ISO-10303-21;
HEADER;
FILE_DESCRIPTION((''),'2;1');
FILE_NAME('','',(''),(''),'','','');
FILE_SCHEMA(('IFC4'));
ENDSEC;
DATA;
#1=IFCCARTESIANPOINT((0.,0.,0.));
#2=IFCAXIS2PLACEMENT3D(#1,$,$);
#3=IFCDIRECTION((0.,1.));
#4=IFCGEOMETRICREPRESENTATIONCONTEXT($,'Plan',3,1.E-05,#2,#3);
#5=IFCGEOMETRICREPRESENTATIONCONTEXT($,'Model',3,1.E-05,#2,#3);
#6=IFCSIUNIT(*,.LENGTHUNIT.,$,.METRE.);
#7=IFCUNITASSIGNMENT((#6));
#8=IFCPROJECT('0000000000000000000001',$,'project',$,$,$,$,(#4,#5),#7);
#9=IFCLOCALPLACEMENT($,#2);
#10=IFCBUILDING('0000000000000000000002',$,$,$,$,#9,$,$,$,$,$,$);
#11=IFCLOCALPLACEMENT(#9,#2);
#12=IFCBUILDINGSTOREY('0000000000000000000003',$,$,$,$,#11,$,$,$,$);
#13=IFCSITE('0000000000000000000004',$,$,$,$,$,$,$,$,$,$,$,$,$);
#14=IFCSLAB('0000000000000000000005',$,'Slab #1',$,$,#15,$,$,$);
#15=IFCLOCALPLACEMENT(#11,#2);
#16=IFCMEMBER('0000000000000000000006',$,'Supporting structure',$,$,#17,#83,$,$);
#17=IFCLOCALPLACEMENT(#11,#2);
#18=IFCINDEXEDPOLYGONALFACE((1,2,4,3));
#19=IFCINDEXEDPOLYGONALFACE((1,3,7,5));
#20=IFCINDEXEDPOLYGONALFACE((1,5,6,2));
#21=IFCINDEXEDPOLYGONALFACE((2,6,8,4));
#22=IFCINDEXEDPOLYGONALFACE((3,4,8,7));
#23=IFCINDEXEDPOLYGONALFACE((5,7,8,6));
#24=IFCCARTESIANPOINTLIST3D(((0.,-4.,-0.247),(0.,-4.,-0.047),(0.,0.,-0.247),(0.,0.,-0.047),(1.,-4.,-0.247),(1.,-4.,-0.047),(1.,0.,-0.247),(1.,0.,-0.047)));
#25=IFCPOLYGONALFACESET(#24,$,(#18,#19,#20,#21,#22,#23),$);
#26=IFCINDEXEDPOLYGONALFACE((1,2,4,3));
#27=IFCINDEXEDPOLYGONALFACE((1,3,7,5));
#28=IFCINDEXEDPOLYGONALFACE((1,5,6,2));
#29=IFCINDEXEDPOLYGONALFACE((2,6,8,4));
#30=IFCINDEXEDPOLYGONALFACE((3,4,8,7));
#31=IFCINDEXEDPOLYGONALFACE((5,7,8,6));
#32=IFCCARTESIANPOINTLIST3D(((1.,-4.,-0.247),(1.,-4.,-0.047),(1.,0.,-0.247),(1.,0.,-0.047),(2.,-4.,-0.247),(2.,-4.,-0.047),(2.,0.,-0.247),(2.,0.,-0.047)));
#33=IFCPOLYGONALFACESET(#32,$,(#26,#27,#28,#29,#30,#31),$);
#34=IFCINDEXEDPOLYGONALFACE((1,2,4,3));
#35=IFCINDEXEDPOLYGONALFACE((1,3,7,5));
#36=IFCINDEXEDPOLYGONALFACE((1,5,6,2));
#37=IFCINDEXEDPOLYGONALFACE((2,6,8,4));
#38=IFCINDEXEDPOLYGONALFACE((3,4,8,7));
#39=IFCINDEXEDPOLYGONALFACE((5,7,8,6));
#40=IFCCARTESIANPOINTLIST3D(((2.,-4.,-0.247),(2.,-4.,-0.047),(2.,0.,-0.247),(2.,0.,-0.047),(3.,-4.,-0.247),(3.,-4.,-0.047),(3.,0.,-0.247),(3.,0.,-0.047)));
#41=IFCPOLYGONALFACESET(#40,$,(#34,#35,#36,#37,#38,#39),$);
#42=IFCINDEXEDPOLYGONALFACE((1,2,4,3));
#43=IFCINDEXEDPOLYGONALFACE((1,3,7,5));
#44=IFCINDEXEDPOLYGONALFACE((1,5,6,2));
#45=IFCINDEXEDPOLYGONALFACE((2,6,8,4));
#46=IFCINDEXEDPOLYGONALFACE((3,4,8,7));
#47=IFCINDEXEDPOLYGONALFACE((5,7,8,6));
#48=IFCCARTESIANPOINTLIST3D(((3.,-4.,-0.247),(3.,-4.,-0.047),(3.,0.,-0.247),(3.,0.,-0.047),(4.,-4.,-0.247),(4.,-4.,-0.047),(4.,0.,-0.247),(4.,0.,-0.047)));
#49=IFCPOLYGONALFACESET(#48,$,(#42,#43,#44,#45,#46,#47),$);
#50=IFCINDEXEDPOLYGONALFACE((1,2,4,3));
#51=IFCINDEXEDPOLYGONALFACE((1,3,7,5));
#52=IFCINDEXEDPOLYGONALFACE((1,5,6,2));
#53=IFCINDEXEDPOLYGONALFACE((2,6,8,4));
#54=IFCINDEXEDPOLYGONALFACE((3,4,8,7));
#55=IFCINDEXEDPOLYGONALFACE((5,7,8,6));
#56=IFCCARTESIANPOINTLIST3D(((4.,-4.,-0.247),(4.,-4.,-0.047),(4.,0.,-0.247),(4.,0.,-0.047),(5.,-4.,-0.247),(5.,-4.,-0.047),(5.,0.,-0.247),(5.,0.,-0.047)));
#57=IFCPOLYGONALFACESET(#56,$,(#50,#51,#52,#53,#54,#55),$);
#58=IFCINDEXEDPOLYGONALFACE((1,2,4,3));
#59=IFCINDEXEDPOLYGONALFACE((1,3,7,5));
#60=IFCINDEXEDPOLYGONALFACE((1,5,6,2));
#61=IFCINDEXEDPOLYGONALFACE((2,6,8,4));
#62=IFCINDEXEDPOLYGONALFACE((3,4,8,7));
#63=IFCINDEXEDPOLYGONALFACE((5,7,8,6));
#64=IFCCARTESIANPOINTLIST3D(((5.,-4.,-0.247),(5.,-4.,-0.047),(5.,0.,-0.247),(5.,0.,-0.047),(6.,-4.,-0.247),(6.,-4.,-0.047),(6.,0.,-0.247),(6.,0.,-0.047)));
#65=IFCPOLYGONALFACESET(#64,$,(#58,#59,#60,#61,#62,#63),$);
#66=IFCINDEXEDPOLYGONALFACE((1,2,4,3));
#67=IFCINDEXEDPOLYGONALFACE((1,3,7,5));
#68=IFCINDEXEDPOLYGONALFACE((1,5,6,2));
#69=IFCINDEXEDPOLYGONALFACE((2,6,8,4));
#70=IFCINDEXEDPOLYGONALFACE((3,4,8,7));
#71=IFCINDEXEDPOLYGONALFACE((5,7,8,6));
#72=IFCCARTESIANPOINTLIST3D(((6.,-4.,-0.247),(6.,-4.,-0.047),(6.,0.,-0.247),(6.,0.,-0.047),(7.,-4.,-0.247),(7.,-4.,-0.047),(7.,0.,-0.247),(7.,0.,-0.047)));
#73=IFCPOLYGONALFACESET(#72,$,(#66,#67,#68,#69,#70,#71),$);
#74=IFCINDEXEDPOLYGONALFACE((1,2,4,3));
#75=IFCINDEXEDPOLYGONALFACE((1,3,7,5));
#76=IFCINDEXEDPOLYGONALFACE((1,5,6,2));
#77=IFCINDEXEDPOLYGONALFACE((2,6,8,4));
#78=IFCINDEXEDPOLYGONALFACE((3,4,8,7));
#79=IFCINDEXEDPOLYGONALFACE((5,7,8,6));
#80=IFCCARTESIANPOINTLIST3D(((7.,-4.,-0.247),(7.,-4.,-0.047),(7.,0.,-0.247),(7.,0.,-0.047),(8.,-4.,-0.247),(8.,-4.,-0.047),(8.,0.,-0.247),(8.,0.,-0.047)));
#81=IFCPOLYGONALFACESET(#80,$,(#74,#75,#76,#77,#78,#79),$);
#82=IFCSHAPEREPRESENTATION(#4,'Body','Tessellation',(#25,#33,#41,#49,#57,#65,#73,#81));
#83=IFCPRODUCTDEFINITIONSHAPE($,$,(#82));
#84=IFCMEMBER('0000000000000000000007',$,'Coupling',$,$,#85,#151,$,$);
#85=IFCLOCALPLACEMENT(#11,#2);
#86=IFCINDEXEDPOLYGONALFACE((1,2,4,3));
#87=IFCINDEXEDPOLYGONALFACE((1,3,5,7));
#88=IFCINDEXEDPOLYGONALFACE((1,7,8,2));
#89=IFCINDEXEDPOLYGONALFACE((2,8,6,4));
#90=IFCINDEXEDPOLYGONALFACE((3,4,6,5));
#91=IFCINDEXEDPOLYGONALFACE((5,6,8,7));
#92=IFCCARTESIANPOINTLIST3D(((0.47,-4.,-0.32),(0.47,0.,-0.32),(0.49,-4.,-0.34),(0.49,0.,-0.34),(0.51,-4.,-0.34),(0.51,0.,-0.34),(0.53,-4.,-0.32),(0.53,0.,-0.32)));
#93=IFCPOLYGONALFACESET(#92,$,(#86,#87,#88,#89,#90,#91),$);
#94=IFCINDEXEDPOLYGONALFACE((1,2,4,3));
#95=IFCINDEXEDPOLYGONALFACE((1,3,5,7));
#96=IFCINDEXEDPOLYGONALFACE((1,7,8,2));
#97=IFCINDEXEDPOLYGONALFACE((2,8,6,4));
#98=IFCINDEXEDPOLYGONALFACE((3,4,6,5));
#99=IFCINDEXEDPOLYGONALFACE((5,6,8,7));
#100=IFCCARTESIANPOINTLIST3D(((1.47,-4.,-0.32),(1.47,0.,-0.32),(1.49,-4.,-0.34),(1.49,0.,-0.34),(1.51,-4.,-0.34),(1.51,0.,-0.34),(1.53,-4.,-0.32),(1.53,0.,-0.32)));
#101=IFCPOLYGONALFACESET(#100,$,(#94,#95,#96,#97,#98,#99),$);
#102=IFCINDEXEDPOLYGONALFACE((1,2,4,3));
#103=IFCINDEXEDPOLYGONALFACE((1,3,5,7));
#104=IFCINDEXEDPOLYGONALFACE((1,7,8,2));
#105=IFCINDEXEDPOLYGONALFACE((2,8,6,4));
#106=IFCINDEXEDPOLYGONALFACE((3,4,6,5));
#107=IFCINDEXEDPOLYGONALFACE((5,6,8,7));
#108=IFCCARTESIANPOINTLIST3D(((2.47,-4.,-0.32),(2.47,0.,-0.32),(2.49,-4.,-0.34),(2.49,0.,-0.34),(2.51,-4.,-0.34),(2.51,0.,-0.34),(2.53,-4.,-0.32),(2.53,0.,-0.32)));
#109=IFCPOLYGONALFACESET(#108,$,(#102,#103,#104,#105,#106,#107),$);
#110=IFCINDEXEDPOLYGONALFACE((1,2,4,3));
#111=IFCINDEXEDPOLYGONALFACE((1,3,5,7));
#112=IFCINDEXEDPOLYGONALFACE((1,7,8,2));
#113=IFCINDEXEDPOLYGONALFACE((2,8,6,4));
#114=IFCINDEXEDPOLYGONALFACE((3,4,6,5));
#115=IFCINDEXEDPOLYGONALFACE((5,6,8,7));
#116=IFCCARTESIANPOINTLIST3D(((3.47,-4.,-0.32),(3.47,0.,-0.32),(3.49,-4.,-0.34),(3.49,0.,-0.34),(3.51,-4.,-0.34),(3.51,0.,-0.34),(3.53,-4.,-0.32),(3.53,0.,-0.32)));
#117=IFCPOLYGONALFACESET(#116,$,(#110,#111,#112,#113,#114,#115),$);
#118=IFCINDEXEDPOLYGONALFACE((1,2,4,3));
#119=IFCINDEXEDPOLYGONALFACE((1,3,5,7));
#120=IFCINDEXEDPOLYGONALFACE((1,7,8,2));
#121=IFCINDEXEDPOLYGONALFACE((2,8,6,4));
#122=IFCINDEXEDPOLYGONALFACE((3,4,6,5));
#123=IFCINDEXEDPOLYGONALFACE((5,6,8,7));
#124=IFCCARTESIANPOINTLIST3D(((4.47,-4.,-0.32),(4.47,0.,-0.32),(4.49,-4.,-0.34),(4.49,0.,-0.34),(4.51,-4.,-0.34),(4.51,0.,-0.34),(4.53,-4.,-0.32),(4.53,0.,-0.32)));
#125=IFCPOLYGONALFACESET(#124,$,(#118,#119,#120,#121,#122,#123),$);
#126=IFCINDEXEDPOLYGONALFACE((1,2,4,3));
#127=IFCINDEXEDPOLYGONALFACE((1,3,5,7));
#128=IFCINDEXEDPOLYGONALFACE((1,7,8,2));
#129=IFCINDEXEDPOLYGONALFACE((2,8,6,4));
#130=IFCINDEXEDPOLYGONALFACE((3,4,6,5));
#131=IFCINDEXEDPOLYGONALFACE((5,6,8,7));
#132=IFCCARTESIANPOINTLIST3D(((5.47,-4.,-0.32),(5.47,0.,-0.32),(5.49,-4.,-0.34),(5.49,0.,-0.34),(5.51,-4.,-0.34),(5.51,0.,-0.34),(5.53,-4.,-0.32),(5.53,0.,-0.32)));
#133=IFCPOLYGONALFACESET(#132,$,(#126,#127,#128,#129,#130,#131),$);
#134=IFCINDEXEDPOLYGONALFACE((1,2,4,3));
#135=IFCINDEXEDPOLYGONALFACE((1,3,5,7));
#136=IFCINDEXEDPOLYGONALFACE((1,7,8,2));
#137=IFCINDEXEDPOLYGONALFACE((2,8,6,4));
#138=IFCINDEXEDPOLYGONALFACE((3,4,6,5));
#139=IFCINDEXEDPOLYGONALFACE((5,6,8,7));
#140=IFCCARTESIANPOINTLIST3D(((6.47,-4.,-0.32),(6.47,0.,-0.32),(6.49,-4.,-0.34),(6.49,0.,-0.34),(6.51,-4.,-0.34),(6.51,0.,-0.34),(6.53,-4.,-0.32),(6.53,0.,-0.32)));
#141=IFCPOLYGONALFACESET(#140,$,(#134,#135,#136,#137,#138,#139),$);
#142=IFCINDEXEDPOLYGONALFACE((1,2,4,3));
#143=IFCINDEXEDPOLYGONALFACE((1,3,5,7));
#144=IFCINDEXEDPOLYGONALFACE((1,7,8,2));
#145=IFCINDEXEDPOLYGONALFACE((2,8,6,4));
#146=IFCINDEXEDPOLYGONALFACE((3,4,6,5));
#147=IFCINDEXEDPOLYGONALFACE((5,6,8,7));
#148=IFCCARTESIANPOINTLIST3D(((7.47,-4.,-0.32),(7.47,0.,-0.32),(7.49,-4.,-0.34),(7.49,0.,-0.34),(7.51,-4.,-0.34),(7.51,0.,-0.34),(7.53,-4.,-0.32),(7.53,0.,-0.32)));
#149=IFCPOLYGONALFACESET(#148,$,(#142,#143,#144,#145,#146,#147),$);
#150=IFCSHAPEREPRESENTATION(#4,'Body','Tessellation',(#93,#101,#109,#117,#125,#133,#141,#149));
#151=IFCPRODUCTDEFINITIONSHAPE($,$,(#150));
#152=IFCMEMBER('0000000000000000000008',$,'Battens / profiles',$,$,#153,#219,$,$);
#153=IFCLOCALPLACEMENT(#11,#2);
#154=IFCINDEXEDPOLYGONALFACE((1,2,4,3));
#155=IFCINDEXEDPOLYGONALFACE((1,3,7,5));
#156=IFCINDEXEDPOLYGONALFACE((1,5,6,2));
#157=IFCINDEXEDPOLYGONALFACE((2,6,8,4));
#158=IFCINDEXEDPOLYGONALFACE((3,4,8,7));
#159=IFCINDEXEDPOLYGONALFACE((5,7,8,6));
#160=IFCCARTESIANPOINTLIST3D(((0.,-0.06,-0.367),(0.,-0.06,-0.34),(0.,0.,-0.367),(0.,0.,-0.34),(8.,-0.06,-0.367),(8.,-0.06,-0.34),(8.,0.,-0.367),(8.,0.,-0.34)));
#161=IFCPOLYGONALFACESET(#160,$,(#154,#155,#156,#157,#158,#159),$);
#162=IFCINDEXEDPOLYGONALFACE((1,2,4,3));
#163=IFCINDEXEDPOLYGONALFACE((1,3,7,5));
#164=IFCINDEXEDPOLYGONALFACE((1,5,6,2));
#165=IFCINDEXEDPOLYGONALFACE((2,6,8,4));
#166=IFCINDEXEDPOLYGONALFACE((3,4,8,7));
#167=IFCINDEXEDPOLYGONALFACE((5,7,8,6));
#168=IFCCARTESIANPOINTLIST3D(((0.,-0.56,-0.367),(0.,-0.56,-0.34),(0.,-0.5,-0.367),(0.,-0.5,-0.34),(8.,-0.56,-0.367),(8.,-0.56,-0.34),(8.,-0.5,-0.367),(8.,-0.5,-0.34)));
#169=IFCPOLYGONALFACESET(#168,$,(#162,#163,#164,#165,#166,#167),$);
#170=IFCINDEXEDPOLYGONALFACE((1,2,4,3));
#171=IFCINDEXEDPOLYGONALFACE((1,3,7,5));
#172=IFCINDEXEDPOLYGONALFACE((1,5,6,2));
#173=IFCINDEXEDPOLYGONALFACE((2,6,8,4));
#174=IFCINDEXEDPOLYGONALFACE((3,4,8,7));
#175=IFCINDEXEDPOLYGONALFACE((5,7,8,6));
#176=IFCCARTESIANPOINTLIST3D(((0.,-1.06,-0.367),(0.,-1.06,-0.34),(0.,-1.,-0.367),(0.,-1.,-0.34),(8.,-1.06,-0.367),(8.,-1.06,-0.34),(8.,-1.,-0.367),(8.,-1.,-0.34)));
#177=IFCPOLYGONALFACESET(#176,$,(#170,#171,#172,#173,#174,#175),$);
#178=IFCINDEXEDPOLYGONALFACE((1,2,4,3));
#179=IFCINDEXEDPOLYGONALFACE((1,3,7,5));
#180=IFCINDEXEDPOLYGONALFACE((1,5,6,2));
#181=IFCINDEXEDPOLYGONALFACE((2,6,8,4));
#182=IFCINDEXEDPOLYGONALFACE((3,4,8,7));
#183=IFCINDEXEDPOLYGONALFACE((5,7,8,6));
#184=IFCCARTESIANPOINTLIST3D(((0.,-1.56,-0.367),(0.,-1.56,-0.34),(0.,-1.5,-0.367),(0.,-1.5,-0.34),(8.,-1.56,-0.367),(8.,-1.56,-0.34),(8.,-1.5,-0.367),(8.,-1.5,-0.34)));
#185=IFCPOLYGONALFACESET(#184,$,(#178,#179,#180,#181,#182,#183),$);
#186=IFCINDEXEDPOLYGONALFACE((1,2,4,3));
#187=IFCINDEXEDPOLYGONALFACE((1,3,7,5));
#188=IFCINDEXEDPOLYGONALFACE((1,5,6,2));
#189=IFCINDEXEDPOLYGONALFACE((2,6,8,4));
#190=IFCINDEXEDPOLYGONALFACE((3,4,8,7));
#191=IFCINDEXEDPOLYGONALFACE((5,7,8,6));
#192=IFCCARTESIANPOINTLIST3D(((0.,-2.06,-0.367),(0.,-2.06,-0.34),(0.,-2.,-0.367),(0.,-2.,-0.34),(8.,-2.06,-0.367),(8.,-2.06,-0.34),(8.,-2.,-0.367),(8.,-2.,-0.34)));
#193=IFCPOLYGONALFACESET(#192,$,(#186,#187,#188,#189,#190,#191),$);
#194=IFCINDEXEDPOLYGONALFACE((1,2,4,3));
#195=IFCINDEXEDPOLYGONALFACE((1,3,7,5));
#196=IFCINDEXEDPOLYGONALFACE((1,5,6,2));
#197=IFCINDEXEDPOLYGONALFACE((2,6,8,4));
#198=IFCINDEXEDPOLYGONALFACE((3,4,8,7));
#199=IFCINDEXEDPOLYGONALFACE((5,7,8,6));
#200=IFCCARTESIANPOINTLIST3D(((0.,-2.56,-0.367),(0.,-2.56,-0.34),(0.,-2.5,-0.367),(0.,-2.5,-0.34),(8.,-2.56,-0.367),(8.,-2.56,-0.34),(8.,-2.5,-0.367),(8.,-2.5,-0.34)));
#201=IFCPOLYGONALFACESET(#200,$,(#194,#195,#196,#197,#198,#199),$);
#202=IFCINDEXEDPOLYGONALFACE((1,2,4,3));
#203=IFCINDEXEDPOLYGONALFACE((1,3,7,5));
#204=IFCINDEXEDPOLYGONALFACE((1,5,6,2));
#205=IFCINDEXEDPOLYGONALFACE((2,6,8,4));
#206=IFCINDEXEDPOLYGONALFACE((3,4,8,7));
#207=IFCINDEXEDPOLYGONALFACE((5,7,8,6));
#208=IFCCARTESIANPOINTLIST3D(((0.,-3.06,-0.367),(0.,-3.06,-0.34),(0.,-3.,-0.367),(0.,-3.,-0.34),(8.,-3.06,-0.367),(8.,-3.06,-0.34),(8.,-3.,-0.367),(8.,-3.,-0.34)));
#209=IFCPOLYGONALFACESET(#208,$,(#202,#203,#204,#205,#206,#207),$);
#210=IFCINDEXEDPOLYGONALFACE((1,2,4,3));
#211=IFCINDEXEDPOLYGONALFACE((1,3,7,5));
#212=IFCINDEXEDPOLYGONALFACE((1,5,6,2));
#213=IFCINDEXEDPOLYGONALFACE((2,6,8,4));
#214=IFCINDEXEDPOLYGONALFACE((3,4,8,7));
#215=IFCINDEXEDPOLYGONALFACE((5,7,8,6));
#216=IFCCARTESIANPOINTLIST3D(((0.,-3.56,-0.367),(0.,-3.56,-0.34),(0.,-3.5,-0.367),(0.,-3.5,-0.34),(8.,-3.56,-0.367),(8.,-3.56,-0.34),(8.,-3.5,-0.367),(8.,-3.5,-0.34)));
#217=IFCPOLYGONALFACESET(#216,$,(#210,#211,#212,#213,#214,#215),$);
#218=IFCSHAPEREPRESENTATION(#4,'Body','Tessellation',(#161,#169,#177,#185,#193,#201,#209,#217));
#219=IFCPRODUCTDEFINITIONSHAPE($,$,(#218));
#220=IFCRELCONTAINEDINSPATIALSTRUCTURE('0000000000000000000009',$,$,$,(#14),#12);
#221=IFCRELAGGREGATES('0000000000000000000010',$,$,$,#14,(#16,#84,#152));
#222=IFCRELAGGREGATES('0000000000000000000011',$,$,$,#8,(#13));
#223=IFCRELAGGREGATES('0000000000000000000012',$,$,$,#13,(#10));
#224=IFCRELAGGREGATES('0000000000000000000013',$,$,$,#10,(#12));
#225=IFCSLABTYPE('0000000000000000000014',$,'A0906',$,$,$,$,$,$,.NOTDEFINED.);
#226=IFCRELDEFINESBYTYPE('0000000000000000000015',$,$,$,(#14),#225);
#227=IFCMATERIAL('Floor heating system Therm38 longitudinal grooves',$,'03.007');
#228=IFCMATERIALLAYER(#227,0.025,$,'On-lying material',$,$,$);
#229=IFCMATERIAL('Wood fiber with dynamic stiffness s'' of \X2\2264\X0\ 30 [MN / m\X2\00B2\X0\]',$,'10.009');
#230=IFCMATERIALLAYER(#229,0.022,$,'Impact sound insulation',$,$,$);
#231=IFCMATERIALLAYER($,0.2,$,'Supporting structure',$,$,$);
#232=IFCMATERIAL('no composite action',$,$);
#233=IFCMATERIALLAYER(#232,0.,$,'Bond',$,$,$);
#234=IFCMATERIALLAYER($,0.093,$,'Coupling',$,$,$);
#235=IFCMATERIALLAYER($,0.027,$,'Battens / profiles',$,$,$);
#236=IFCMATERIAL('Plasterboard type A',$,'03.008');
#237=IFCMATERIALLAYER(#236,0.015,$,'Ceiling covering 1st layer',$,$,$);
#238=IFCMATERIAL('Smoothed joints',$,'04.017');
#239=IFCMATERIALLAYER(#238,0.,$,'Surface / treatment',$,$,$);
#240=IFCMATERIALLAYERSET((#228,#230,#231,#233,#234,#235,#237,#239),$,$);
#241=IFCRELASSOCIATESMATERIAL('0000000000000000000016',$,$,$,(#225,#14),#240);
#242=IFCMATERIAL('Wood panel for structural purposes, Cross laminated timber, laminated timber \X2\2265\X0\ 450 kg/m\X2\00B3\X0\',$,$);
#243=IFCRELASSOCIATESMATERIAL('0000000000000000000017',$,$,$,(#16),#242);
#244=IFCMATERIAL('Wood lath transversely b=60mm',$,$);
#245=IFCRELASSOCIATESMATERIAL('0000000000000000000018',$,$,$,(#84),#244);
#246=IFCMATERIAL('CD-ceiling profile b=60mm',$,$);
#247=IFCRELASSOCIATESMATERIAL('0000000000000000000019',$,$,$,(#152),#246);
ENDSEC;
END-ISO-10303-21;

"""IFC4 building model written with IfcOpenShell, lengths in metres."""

from ifc_helpers import new_model, si_unit, direction, frame, frame_2d, origin, place, context, project, spatial, polyline, rectangle, outline, extrude, material, layer, layer_set, type_object, element, aggregate, save


model = new_model("IFC4")

# Units and contexts
plan_context = context("Plan", 3, precision=1e-05, world=origin(), true_north=direction((0.0, 1.0)))
model_context = context("Model", 3, precision=1e-05, world=origin(), true_north=direction((0.0, 1.0)))
ifc_project = project(units=[si_unit("LENGTHUNIT", "METRE")], contexts=[plan_context, model_context])

# Site, building, storey
site = spatial("IfcSite", under=ifc_project)
building_placement = place(None, origin())
building = spatial("IfcBuilding", under=site, at=building_placement)
storey_placement = place(building_placement, origin())
storey = spatial("IfcBuildingStorey", under=building, at=storey_placement)

# Slab, members
ifc_material_1 = material(Name="Floor heating system Therm38 longitudinal grooves", Category="03.007")
ifc_layer_1 = layer(ifc_material_1, 0.025, Name="On-lying material")
ifc_material_2 = material(Name="Wood fiber with dynamic stiffness s' of ≤ 30 [MN / m²]", Category="10.009")
ifc_layer_2 = layer(ifc_material_2, 0.022, Name="Impact sound insulation")
ifc_layer_3 = layer(None, 0.2, Name="Supporting structure")
ifc_material_3 = material(Name="no composite action")
ifc_layer_4 = layer(ifc_material_3, 0.0, Name="Bond")
ifc_layer_5 = layer(None, 0.093, Name="Coupling")
ifc_layer_6 = layer(None, 0.027, Name="Battens / profiles")
ifc_material_4 = material(Name="Plasterboard type A", Category="03.008")
ifc_layer_7 = layer(ifc_material_4, 0.015, Name="Ceiling covering 1st layer")
ifc_material_5 = material(Name="Smoothed joints", Category="04.017")
ifc_layer_8 = layer(ifc_material_5, 0.0, Name="Surface / treatment")
ifc_layer_set = layer_set([ifc_layer_1, ifc_layer_2, ifc_layer_3, ifc_layer_4, ifc_layer_5, ifc_layer_6, ifc_layer_7, ifc_layer_8])
slab_type = type_object("IfcSlabType", Name="A0906", PredefinedType="NOTDEFINED", material=ifc_layer_set)
slab_placement = place(None, frame((0.0, 0.0, 0.0), z_axis=(0.0, 0.0, -1.0), x_axis=(1.0, 0.0, 0.0)))
slab = element("IfcSlab", 1, at=slab_placement, inside=storey, type_object=slab_type, material=ifc_layer_set, Name="Slab #1")
ifc_material_6 = material(Name="Wood panel for structural purposes, Cross laminated timber, laminated timber ≥ 450 kg/m³")
member_1_placement = place(slab_placement, origin())
member_1 = element("IfcMember", 2, at=member_1_placement, material=ifc_material_6, Name="Supporting structure", context=plan_context, shape_type="SweptSolid", body=[
    extrude(rectangle(XDim=1.0, YDim=0.2, at=frame_2d((0.5, 0.1), x_axis=(1.0, 0.0))), frame((0.0, 4.0, 0.047), z_axis=(0.0, -1.0, 0.0), x_axis=(1.0, 0.0, 0.0)), (0.0, 0.0, 1.0), 4.0),
    extrude(rectangle(XDim=1.0, YDim=0.2, at=frame_2d((0.5, 0.1), x_axis=(1.0, 0.0))), frame((1.0, 4.0, 0.047), z_axis=(0.0, -1.0, 0.0), x_axis=(1.0, 0.0, 0.0)), (0.0, 0.0, 1.0), 4.0),
    extrude(rectangle(XDim=1.0, YDim=0.2, at=frame_2d((0.5, 0.1), x_axis=(1.0, 0.0))), frame((2.0, 4.0, 0.047), z_axis=(0.0, -1.0, 0.0), x_axis=(1.0, 0.0, 0.0)), (0.0, 0.0, 1.0), 4.0),
    extrude(rectangle(XDim=1.0, YDim=0.2, at=frame_2d((0.5, 0.1), x_axis=(1.0, 0.0))), frame((3.0, 4.0, 0.047), z_axis=(0.0, -1.0, 0.0), x_axis=(1.0, 0.0, 0.0)), (0.0, 0.0, 1.0), 4.0),
    extrude(rectangle(XDim=1.0, YDim=0.2, at=frame_2d((0.5, 0.1), x_axis=(1.0, 0.0))), frame((4.0, 4.0, 0.047), z_axis=(0.0, -1.0, 0.0), x_axis=(1.0, 0.0, 0.0)), (0.0, 0.0, 1.0), 4.0),
    extrude(rectangle(XDim=1.0, YDim=0.2, at=frame_2d((0.5, 0.1), x_axis=(1.0, 0.0))), frame((5.0, 4.0, 0.047), z_axis=(0.0, -1.0, 0.0), x_axis=(1.0, 0.0, 0.0)), (0.0, 0.0, 1.0), 4.0),
    extrude(rectangle(XDim=1.0, YDim=0.2, at=frame_2d((0.5, 0.1), x_axis=(1.0, 0.0))), frame((6.0, 4.0, 0.047), z_axis=(0.0, -1.0, 0.0), x_axis=(1.0, 0.0, 0.0)), (0.0, 0.0, 1.0), 4.0),
    extrude(rectangle(XDim=1.0, YDim=0.2, at=frame_2d((0.5, 0.1), x_axis=(1.0, 0.0))), frame((7.0, 4.0, 0.047), z_axis=(0.0, -1.0, 0.0), x_axis=(1.0, 0.0, 0.0)), (0.0, 0.0, 1.0), 4.0),
])
ifc_material_7 = material(Name="Wood lath transversely b=60mm")
member_2_placement = place(slab_placement, origin())
member_2 = element("IfcMember", 3, at=member_2_placement, material=ifc_material_7, Name="Coupling", context=plan_context, shape_type="SweptSolid", body=[
    extrude(outline(polyline([(0.0, 0.0), (0.06, 0.0), (0.04, 0.02), (0.02, 0.02), (0.0, 0.0)])), frame((0.47, 4.0, 0.32), z_axis=(0.0, -1.0, 0.0), x_axis=(1.0, 0.0, 0.0)), (0.0, 0.0, 1.0), 4.0),
    extrude(outline(polyline([(0.0, 0.0), (0.06, 0.0), (0.04, 0.02), (0.02, 0.02), (0.0, 0.0)])), frame((1.47, 4.0, 0.32), z_axis=(0.0, -1.0, 0.0), x_axis=(1.0, 0.0, 0.0)), (0.0, 0.0, 1.0), 4.0),
    extrude(outline(polyline([(0.0, 0.0), (0.06, 0.0), (0.04, 0.02), (0.02, 0.02), (0.0, 0.0)])), frame((2.47, 4.0, 0.32), z_axis=(0.0, -1.0, 0.0), x_axis=(1.0, 0.0, 0.0)), (0.0, 0.0, 1.0), 4.0),
    extrude(outline(polyline([(0.0, 0.0), (0.06, 0.0), (0.04, 0.02), (0.02, 0.02), (0.0, 0.0)])), frame((3.47, 4.0, 0.32), z_axis=(0.0, -1.0, 0.0), x_axis=(1.0, 0.0, 0.0)), (0.0, 0.0, 1.0), 4.0),
    extrude(outline(polyline([(0.0, 0.0), (0.06, 0.0), (0.04, 0.02), (0.02, 0.02), (0.0, 0.0)])), frame((4.47, 4.0, 0.32), z_axis=(0.0, -1.0, 0.0), x_axis=(1.0, 0.0, 0.0)), (0.0, 0.0, 1.0), 4.0),
    extrude(outline(polyline([(0.0, 0.0), (0.06, 0.0), (0.04, 0.02), (0.02, 0.02), (0.0, 0.0)])), frame((5.47, 4.0, 0.32), z_axis=(0.0, -1.0, 0.0), x_axis=(1.0, 0.0, 0.0)), (0.0, 0.0, 1.0), 4.0),
    extrude(outline(polyline([(0.0, 0.0), (0.06, 0.0), (0.04, 0.02), (0.02, 0.02), (0.0, 0.0)])), frame((6.47, 4.0, 0.32), z_axis=(0.0, -1.0, 0.0), x_axis=(1.0, 0.0, 0.0)), (0.0, 0.0, 1.0), 4.0),
    extrude(outline(polyline([(0.0, 0.0), (0.06, 0.0), (0.04, 0.02), (0.02, 0.02), (0.0, 0.0)])), frame((7.47, 4.0, 0.32), z_axis=(0.0, -1.0, 0.0), x_axis=(1.0, 0.0, 0.0)), (0.0, 0.0, 1.0), 4.0),
])
ifc_material_8 = material(Name="CD-ceiling profile b=60mm")
member_3_placement = place(slab_placement, origin())
member_3 = element("IfcMember", 4, at=member_3_placement, material=ifc_material_8, Name="Battens / profiles", context=plan_context, shape_type="SweptSolid", body=[
    extrude(rectangle(XDim=0.06, YDim=0.027, at=frame_2d((0.03, 0.0135), x_axis=(1.0, 0.0))), frame((0.0, 0.0, 0.34), z_axis=(1.0, 0.0, 0.0), x_axis=(0.0, 1.0, 0.0)), (0.0, 0.0, 1.0), 8.0),
    extrude(rectangle(XDim=0.06, YDim=0.027, at=frame_2d((0.03, 0.0135), x_axis=(1.0, 0.0))), frame((0.0, 0.5, 0.34), z_axis=(1.0, 0.0, 0.0), x_axis=(0.0, 1.0, 0.0)), (0.0, 0.0, 1.0), 8.0),
    extrude(rectangle(XDim=0.06, YDim=0.027, at=frame_2d((0.03, 0.0135), x_axis=(1.0, 0.0))), frame((0.0, 1.0, 0.34), z_axis=(1.0, 0.0, 0.0), x_axis=(0.0, 1.0, 0.0)), (0.0, 0.0, 1.0), 8.0),
    extrude(rectangle(XDim=0.06, YDim=0.027, at=frame_2d((0.03, 0.0135), x_axis=(1.0, 0.0))), frame((0.0, 1.5, 0.34), z_axis=(1.0, 0.0, 0.0), x_axis=(0.0, 1.0, 0.0)), (0.0, 0.0, 1.0), 8.0),
    extrude(rectangle(XDim=0.06, YDim=0.027, at=frame_2d((0.03, 0.0135), x_axis=(1.0, 0.0))), frame((0.0, 2.0, 0.34), z_axis=(1.0, 0.0, 0.0), x_axis=(0.0, 1.0, 0.0)), (0.0, 0.0, 1.0), 8.0),
    extrude(rectangle(XDim=0.06, YDim=0.027, at=frame_2d((0.03, 0.0135), x_axis=(1.0, 0.0))), frame((0.0, 2.5, 0.34), z_axis=(1.0, 0.0, 0.0), x_axis=(0.0, 1.0, 0.0)), (0.0, 0.0, 1.0), 8.0),
    extrude(rectangle(XDim=0.06, YDim=0.027, at=frame_2d((0.03, 0.0135), x_axis=(1.0, 0.0))), frame((0.0, 3.0, 0.34), z_axis=(1.0, 0.0, 0.0), x_axis=(0.0, 1.0, 0.0)), (0.0, 0.0, 1.0), 8.0),
    extrude(rectangle(XDim=0.06, YDim=0.027, at=frame_2d((0.03, 0.0135), x_axis=(1.0, 0.0))), frame((0.0, 3.5, 0.34), z_axis=(1.0, 0.0, 0.0), x_axis=(0.0, 1.0, 0.0)), (0.0, 0.0, 1.0), 8.0),
])
aggregate(slab, [member_1, member_2, member_3])

save(model, "model.ifc")
